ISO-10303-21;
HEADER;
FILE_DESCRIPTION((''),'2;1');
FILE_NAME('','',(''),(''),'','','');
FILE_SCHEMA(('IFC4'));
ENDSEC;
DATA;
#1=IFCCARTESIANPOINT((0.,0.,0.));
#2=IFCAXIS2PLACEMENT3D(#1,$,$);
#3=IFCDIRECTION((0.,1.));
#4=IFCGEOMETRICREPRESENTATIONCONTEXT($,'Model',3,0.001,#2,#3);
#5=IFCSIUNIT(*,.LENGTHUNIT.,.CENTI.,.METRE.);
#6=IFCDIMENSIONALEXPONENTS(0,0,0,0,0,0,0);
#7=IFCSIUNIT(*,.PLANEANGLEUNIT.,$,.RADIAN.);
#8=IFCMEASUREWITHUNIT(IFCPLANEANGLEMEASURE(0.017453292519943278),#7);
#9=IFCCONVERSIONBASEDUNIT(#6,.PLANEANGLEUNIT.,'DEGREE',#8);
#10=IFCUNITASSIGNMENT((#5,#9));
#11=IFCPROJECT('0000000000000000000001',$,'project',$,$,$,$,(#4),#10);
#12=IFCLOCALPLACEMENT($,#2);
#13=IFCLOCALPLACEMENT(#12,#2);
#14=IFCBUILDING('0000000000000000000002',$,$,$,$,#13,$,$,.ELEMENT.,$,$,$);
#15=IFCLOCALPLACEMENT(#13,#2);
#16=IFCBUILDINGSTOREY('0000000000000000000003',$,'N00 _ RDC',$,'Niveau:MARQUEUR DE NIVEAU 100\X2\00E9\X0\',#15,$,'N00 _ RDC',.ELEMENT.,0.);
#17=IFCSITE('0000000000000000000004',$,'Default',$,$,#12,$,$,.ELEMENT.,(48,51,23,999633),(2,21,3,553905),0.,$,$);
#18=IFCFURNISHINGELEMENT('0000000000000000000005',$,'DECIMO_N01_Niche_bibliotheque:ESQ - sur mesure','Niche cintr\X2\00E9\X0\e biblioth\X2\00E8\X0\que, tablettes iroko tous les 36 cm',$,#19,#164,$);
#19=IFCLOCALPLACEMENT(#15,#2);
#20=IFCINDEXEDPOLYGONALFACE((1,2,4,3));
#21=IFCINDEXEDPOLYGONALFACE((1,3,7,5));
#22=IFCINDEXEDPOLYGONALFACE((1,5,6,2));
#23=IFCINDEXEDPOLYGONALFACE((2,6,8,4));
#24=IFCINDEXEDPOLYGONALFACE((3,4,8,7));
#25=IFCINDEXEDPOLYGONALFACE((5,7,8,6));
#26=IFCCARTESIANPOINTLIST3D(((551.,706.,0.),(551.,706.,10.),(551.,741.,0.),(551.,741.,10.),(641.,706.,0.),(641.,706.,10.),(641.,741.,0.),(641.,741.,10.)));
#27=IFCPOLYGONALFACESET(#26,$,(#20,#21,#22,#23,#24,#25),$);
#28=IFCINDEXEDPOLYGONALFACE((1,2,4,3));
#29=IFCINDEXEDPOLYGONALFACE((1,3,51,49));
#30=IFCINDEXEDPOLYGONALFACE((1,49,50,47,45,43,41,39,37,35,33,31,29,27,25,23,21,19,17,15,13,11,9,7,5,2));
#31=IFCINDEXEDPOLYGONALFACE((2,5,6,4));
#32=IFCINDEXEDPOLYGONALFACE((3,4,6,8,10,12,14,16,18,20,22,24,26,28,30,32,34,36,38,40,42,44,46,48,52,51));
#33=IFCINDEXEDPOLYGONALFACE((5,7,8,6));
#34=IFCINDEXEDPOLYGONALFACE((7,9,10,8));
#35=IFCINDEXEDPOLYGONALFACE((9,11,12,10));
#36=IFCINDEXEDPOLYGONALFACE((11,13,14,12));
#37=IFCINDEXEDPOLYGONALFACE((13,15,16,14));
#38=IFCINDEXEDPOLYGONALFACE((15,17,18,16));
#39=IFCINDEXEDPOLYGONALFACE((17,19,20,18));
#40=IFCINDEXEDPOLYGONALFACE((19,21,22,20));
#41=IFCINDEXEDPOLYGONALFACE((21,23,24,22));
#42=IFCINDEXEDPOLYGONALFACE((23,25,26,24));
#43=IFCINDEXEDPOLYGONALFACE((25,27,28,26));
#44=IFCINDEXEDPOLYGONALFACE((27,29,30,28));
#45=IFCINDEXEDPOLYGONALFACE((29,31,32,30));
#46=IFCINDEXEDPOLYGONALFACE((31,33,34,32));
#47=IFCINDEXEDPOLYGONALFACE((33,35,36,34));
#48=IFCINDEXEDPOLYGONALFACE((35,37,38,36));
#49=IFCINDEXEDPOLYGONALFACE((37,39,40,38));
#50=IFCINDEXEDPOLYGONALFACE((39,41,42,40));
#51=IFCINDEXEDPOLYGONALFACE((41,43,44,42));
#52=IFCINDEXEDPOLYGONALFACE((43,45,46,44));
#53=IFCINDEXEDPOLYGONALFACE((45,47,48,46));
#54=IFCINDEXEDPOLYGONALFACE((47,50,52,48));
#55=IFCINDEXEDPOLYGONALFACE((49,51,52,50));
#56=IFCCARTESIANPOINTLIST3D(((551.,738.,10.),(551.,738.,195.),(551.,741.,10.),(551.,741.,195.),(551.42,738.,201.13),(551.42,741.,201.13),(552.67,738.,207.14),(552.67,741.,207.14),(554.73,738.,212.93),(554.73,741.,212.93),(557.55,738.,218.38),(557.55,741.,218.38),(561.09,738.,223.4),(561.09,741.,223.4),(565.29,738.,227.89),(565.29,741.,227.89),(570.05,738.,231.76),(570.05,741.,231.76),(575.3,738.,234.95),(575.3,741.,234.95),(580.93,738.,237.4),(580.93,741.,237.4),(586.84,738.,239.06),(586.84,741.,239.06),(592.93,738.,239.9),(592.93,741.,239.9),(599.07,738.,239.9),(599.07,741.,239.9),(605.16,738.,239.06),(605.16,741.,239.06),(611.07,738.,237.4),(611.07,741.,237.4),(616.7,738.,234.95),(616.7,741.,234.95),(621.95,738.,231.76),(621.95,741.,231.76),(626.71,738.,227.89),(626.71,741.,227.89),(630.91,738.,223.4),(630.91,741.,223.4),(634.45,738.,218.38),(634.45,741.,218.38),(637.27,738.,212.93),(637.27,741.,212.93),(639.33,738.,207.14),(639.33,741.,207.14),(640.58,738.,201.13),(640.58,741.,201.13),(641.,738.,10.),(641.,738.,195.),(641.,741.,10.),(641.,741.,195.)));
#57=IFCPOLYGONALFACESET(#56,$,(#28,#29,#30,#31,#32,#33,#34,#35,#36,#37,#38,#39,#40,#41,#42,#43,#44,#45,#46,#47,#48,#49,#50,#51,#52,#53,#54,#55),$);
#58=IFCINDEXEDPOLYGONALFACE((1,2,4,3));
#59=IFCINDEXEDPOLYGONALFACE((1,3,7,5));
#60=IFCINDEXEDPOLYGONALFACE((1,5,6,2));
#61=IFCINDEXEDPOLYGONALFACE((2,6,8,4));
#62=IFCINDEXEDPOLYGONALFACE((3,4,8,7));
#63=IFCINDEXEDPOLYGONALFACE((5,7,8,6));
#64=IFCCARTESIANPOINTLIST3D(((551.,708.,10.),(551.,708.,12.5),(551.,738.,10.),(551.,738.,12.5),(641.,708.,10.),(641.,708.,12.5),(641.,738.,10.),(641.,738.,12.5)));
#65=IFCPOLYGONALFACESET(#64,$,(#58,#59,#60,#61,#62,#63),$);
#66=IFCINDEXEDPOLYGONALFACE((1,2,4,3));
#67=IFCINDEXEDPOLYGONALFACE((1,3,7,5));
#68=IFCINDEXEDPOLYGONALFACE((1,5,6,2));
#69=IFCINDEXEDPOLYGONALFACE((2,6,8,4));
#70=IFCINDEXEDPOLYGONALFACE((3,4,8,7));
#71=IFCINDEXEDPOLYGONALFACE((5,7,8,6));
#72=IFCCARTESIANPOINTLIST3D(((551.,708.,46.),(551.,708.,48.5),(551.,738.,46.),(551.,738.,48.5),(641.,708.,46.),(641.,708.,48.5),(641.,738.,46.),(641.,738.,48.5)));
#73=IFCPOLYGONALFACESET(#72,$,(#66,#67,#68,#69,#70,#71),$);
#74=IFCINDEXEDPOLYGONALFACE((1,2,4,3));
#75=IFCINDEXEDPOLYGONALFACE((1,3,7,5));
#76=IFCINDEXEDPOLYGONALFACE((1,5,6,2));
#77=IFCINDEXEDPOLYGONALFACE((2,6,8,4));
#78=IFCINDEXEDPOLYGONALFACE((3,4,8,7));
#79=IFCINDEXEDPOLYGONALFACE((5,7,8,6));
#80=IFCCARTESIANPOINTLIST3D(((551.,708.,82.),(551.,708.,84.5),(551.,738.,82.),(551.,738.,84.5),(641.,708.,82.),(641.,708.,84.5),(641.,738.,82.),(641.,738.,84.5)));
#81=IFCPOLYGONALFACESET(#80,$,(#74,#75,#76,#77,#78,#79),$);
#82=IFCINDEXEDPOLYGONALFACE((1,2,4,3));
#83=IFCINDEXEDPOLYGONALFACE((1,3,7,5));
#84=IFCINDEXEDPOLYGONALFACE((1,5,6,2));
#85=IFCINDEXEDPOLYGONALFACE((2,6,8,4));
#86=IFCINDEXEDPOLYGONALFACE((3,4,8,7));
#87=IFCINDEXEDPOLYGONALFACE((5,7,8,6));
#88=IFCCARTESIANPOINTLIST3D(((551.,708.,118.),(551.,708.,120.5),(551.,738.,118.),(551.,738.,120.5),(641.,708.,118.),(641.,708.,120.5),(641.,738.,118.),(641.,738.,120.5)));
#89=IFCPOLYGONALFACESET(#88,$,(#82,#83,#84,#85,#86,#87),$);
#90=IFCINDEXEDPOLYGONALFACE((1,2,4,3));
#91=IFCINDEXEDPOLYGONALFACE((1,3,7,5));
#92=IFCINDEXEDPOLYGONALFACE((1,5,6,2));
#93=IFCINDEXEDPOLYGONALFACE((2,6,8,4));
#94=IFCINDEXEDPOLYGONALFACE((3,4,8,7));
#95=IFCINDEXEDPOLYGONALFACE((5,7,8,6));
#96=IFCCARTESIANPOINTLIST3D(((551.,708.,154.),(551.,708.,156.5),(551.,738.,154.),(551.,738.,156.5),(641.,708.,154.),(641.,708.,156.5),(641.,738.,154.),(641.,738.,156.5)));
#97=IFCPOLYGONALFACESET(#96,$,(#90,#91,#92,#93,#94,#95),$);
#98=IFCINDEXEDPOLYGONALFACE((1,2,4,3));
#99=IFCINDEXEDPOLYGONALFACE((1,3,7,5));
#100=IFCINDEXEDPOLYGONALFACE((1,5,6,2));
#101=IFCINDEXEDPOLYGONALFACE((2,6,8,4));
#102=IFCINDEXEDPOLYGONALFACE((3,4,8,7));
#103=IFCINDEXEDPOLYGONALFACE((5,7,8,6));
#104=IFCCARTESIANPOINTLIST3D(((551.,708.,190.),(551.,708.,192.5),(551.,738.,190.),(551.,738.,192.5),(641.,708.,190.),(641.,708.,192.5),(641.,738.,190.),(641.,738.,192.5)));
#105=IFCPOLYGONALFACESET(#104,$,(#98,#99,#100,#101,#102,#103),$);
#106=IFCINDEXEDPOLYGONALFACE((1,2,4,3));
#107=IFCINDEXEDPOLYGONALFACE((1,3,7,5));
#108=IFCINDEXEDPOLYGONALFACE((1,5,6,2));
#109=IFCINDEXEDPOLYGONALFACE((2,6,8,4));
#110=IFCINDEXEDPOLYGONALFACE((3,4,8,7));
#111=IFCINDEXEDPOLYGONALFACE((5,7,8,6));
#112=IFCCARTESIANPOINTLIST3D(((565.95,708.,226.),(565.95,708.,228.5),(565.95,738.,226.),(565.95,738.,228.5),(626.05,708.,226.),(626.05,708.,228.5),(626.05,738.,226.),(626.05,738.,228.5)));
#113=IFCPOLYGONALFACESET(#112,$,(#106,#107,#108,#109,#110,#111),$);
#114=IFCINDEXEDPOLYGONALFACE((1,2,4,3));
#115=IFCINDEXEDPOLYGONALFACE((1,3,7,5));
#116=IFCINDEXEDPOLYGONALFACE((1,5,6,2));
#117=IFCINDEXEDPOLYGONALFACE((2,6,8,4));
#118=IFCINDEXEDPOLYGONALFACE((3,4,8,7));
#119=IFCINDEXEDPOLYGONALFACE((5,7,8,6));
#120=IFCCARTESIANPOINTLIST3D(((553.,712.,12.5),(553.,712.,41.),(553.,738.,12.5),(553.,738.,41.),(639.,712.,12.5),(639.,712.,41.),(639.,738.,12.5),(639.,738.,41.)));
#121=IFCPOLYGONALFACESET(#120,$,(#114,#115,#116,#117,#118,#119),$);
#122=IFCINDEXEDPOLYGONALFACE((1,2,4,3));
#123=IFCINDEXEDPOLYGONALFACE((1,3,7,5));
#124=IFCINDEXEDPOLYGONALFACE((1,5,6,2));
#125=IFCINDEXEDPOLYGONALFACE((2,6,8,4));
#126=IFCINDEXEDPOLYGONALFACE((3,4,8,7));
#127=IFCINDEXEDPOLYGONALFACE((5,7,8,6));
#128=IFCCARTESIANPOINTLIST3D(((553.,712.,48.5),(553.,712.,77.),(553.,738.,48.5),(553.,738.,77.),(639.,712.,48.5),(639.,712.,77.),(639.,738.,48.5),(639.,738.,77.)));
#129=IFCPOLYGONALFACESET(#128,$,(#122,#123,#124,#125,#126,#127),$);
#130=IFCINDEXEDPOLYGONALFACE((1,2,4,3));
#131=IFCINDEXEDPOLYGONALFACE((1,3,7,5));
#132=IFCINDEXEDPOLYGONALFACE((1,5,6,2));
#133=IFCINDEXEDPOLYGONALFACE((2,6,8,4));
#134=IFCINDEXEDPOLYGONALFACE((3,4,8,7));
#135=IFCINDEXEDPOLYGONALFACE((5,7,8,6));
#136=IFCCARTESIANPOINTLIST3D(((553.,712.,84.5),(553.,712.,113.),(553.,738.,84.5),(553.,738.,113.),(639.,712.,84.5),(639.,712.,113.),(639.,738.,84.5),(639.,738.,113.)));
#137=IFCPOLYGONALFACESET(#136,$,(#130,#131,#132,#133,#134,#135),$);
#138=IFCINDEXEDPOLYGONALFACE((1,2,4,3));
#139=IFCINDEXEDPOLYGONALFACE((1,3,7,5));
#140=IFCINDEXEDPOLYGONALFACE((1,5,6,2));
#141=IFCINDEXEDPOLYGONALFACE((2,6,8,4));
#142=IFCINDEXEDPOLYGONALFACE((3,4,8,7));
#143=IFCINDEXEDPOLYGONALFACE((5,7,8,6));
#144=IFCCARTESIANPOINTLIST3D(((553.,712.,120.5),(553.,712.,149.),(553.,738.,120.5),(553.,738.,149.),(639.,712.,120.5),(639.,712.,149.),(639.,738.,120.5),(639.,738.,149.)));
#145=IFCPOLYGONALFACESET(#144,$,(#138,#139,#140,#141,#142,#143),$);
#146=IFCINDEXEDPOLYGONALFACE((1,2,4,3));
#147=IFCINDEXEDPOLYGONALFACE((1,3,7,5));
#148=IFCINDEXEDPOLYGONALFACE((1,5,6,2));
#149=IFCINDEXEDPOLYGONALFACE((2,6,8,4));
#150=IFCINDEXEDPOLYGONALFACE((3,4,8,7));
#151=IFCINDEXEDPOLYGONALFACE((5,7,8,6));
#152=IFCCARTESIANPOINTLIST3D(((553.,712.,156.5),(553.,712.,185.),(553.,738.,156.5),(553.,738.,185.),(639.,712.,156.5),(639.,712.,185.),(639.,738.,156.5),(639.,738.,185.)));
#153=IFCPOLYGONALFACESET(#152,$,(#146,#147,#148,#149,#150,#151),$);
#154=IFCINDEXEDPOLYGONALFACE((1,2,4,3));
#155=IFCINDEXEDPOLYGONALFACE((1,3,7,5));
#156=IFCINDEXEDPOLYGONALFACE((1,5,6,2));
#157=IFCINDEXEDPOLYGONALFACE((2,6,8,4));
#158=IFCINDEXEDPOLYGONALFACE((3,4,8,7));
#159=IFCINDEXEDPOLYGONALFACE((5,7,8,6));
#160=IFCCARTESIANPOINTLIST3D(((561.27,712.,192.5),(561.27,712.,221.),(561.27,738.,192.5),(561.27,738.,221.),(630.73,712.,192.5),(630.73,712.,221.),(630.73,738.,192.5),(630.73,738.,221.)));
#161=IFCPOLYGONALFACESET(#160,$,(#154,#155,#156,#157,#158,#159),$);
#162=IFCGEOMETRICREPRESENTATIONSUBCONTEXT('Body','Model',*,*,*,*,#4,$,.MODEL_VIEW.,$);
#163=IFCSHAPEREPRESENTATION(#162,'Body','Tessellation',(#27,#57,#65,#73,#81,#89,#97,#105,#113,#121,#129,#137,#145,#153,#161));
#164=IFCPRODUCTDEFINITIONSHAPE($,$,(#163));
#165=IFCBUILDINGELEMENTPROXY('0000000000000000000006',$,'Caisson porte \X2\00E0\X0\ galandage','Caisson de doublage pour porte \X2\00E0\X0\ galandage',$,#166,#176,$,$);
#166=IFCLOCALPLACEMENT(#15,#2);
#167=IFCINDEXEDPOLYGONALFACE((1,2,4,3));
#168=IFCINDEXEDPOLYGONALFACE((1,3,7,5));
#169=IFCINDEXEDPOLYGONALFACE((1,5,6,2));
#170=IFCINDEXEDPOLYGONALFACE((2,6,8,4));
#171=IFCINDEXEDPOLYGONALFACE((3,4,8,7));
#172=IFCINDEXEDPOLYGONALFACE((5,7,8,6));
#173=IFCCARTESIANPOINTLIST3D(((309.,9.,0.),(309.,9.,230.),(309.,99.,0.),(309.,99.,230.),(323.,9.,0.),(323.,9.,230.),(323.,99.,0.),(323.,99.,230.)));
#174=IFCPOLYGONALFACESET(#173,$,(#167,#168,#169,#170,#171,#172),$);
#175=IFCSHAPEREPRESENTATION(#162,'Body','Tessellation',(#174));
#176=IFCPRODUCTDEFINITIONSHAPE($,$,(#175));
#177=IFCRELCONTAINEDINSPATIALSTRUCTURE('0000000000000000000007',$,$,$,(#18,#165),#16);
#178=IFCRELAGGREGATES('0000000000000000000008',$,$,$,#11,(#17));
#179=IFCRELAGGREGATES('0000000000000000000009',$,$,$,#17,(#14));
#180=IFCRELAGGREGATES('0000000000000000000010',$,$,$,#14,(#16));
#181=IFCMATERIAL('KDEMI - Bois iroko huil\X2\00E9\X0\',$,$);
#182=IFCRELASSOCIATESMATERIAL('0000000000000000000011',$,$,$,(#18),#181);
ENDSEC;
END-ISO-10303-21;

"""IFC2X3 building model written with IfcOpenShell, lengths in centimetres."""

from ifc_helpers import new_model, entity, si_unit, converted_unit, direction, frame, frame_2d, origin, origin_with_axes, place, context, subcontext, project, spatial, polyline, rectangle, outline, extrude, material, element, save


model = new_model("IFC2X3")

# Units and contexts
model_context = context("Model", 3, precision=0.001, world=origin(), true_north=direction((0.0, 1.0)))
body_context = subcontext(model_context, "Body", "Model", "MODEL_VIEW")
ifc_project = project(units=[si_unit("LENGTHUNIT", "METRE", prefix="CENTI"), converted_unit("PLANEANGLEUNIT", "DEGREE", entity("IfcPlaneAngleMeasure", 0.017453292519943278), si_unit("PLANEANGLEUNIT", "RADIAN"), dimensions=[0, 0, 0, 0, 0, 0, 0])], contexts=[model_context])

# Site, building, storey
site_placement = place(None, origin())
site = spatial("IfcSite", under=ifc_project, at=site_placement, Name="Default", CompositionType="ELEMENT", RefLatitude=(48, 51, 23, 999633), RefLongitude=(2, 21, 3, 553905), RefElevation=0.0)
building_placement = place(site_placement, origin())
building = spatial("IfcBuilding", under=site, at=building_placement, CompositionType="ELEMENT")
storey_placement = place(building_placement, origin())
storey = spatial("IfcBuildingStorey", under=building, at=storey_placement, Name="N00 _ RDC", ObjectType="Niveau:MARQUEUR DE NIVEAU 100é", LongName="N00 _ RDC", CompositionType="ELEMENT", Elevation=0.0)

# Furnishing element
ifc_material_1 = material(Name="KDEMI - Bois iroko huilé")
furnishing_1_placement = place(storey_placement, origin_with_axes())
element("IfcFurnishingElement", 1, at=furnishing_1_placement, inside=storey, material=ifc_material_1, Name="DECIMO_N01_Niche_bibliotheque:ESQ - sur mesure", Description="Niche cintrée bibliothèque, tablettes iroko tous les 36 cm", context=body_context, shape_type="SweptSolid", body=[
    extrude(rectangle(XDim=90.0, YDim=35.0, at=frame_2d((596.0, 723.5))), origin(), (0.0, 0.0, 1.0), 10.0),
    extrude(outline(polyline([(551.0, 10.0), (641.0, 10.0), (641.0, 195.0), (640.58, 201.13), (639.33, 207.14), (637.27, 212.93), (634.45, 218.38), (630.91, 223.4), (626.71, 227.89), (621.95, 231.76), (616.7, 234.95), (611.07, 237.4), (605.16, 239.06), (599.07, 239.9), (592.93, 239.9), (586.84, 239.06), (580.93, 237.4), (575.3, 234.95), (570.05, 231.76), (565.29, 227.89), (561.09, 223.4), (557.55, 218.38), (554.73, 212.93), (552.67, 207.14), (551.42, 201.13), (551.0, 195.0), (551.0, 10.0)])), frame((0.0, 741.0, 0.0), z_axis=(0.0, -1.0, 0.0), x_axis=(1.0, 0.0, 0.0)), (0.0, 0.0, 1.0), 3.0),
    extrude(rectangle(XDim=90.0, YDim=30.0, at=frame_2d((596.0, 723.0))), frame((0.0, 0.0, 10.0)), (0.0, 0.0, 1.0), 2.5),
    extrude(rectangle(XDim=90.0, YDim=30.0, at=frame_2d((596.0, 723.0))), frame((0.0, 0.0, 46.0)), (0.0, 0.0, 1.0), 2.5),
    extrude(rectangle(XDim=90.0, YDim=30.0, at=frame_2d((596.0, 723.0))), frame((0.0, 0.0, 82.0)), (0.0, 0.0, 1.0), 2.5),
    extrude(rectangle(XDim=90.0, YDim=30.0, at=frame_2d((596.0, 723.0))), frame((0.0, 0.0, 118.0)), (0.0, 0.0, 1.0), 2.5),
    extrude(rectangle(XDim=90.0, YDim=30.0, at=frame_2d((596.0, 723.0))), frame((0.0, 0.0, 154.0)), (0.0, 0.0, 1.0), 2.5),
    extrude(rectangle(XDim=90.0, YDim=30.0, at=frame_2d((596.0, 723.0))), frame((0.0, 0.0, 190.0)), (0.0, 0.0, 1.0), 2.5),
    extrude(rectangle(XDim=60.09, YDim=30.0, at=frame_2d((596.0, 723.0))), frame((0.0, 0.0, 226.0)), (0.0, 0.0, 1.0), 2.5),
    extrude(rectangle(XDim=86.0, YDim=26.0, at=frame_2d((596.0, 725.0))), frame((0.0, 0.0, 12.5)), (0.0, 0.0, 1.0), 28.5),
    extrude(rectangle(XDim=86.0, YDim=26.0, at=frame_2d((596.0, 725.0))), frame((0.0, 0.0, 48.5)), (0.0, 0.0, 1.0), 28.5),
    extrude(rectangle(XDim=86.0, YDim=26.0, at=frame_2d((596.0, 725.0))), frame((0.0, 0.0, 84.5)), (0.0, 0.0, 1.0), 28.5),
    extrude(rectangle(XDim=86.0, YDim=26.0, at=frame_2d((596.0, 725.0))), frame((0.0, 0.0, 120.5)), (0.0, 0.0, 1.0), 28.5),
    extrude(rectangle(XDim=86.0, YDim=26.0, at=frame_2d((596.0, 725.0))), frame((0.0, 0.0, 156.5)), (0.0, 0.0, 1.0), 28.5),
    extrude(rectangle(XDim=69.46, YDim=26.0, at=frame_2d((596.0, 725.0))), frame((0.0, 0.0, 192.5)), (0.0, 0.0, 1.0), 28.5),
])

# Building element proxy
proxy_1_placement = place(storey_placement, origin_with_axes())
element("IfcBuildingElementProxy", 2, at=proxy_1_placement, inside=storey, Name="Caisson porte à galandage", Description="Caisson de doublage pour porte à galandage", context=body_context, shape_type="SweptSolid", body=[
    extrude(rectangle(XDim=14.0, YDim=90.0, at=frame_2d((316.0, 54.0))), origin(), (0.0, 0.0, 1.0), 230.0),
])

save(model, "model.ifc")
